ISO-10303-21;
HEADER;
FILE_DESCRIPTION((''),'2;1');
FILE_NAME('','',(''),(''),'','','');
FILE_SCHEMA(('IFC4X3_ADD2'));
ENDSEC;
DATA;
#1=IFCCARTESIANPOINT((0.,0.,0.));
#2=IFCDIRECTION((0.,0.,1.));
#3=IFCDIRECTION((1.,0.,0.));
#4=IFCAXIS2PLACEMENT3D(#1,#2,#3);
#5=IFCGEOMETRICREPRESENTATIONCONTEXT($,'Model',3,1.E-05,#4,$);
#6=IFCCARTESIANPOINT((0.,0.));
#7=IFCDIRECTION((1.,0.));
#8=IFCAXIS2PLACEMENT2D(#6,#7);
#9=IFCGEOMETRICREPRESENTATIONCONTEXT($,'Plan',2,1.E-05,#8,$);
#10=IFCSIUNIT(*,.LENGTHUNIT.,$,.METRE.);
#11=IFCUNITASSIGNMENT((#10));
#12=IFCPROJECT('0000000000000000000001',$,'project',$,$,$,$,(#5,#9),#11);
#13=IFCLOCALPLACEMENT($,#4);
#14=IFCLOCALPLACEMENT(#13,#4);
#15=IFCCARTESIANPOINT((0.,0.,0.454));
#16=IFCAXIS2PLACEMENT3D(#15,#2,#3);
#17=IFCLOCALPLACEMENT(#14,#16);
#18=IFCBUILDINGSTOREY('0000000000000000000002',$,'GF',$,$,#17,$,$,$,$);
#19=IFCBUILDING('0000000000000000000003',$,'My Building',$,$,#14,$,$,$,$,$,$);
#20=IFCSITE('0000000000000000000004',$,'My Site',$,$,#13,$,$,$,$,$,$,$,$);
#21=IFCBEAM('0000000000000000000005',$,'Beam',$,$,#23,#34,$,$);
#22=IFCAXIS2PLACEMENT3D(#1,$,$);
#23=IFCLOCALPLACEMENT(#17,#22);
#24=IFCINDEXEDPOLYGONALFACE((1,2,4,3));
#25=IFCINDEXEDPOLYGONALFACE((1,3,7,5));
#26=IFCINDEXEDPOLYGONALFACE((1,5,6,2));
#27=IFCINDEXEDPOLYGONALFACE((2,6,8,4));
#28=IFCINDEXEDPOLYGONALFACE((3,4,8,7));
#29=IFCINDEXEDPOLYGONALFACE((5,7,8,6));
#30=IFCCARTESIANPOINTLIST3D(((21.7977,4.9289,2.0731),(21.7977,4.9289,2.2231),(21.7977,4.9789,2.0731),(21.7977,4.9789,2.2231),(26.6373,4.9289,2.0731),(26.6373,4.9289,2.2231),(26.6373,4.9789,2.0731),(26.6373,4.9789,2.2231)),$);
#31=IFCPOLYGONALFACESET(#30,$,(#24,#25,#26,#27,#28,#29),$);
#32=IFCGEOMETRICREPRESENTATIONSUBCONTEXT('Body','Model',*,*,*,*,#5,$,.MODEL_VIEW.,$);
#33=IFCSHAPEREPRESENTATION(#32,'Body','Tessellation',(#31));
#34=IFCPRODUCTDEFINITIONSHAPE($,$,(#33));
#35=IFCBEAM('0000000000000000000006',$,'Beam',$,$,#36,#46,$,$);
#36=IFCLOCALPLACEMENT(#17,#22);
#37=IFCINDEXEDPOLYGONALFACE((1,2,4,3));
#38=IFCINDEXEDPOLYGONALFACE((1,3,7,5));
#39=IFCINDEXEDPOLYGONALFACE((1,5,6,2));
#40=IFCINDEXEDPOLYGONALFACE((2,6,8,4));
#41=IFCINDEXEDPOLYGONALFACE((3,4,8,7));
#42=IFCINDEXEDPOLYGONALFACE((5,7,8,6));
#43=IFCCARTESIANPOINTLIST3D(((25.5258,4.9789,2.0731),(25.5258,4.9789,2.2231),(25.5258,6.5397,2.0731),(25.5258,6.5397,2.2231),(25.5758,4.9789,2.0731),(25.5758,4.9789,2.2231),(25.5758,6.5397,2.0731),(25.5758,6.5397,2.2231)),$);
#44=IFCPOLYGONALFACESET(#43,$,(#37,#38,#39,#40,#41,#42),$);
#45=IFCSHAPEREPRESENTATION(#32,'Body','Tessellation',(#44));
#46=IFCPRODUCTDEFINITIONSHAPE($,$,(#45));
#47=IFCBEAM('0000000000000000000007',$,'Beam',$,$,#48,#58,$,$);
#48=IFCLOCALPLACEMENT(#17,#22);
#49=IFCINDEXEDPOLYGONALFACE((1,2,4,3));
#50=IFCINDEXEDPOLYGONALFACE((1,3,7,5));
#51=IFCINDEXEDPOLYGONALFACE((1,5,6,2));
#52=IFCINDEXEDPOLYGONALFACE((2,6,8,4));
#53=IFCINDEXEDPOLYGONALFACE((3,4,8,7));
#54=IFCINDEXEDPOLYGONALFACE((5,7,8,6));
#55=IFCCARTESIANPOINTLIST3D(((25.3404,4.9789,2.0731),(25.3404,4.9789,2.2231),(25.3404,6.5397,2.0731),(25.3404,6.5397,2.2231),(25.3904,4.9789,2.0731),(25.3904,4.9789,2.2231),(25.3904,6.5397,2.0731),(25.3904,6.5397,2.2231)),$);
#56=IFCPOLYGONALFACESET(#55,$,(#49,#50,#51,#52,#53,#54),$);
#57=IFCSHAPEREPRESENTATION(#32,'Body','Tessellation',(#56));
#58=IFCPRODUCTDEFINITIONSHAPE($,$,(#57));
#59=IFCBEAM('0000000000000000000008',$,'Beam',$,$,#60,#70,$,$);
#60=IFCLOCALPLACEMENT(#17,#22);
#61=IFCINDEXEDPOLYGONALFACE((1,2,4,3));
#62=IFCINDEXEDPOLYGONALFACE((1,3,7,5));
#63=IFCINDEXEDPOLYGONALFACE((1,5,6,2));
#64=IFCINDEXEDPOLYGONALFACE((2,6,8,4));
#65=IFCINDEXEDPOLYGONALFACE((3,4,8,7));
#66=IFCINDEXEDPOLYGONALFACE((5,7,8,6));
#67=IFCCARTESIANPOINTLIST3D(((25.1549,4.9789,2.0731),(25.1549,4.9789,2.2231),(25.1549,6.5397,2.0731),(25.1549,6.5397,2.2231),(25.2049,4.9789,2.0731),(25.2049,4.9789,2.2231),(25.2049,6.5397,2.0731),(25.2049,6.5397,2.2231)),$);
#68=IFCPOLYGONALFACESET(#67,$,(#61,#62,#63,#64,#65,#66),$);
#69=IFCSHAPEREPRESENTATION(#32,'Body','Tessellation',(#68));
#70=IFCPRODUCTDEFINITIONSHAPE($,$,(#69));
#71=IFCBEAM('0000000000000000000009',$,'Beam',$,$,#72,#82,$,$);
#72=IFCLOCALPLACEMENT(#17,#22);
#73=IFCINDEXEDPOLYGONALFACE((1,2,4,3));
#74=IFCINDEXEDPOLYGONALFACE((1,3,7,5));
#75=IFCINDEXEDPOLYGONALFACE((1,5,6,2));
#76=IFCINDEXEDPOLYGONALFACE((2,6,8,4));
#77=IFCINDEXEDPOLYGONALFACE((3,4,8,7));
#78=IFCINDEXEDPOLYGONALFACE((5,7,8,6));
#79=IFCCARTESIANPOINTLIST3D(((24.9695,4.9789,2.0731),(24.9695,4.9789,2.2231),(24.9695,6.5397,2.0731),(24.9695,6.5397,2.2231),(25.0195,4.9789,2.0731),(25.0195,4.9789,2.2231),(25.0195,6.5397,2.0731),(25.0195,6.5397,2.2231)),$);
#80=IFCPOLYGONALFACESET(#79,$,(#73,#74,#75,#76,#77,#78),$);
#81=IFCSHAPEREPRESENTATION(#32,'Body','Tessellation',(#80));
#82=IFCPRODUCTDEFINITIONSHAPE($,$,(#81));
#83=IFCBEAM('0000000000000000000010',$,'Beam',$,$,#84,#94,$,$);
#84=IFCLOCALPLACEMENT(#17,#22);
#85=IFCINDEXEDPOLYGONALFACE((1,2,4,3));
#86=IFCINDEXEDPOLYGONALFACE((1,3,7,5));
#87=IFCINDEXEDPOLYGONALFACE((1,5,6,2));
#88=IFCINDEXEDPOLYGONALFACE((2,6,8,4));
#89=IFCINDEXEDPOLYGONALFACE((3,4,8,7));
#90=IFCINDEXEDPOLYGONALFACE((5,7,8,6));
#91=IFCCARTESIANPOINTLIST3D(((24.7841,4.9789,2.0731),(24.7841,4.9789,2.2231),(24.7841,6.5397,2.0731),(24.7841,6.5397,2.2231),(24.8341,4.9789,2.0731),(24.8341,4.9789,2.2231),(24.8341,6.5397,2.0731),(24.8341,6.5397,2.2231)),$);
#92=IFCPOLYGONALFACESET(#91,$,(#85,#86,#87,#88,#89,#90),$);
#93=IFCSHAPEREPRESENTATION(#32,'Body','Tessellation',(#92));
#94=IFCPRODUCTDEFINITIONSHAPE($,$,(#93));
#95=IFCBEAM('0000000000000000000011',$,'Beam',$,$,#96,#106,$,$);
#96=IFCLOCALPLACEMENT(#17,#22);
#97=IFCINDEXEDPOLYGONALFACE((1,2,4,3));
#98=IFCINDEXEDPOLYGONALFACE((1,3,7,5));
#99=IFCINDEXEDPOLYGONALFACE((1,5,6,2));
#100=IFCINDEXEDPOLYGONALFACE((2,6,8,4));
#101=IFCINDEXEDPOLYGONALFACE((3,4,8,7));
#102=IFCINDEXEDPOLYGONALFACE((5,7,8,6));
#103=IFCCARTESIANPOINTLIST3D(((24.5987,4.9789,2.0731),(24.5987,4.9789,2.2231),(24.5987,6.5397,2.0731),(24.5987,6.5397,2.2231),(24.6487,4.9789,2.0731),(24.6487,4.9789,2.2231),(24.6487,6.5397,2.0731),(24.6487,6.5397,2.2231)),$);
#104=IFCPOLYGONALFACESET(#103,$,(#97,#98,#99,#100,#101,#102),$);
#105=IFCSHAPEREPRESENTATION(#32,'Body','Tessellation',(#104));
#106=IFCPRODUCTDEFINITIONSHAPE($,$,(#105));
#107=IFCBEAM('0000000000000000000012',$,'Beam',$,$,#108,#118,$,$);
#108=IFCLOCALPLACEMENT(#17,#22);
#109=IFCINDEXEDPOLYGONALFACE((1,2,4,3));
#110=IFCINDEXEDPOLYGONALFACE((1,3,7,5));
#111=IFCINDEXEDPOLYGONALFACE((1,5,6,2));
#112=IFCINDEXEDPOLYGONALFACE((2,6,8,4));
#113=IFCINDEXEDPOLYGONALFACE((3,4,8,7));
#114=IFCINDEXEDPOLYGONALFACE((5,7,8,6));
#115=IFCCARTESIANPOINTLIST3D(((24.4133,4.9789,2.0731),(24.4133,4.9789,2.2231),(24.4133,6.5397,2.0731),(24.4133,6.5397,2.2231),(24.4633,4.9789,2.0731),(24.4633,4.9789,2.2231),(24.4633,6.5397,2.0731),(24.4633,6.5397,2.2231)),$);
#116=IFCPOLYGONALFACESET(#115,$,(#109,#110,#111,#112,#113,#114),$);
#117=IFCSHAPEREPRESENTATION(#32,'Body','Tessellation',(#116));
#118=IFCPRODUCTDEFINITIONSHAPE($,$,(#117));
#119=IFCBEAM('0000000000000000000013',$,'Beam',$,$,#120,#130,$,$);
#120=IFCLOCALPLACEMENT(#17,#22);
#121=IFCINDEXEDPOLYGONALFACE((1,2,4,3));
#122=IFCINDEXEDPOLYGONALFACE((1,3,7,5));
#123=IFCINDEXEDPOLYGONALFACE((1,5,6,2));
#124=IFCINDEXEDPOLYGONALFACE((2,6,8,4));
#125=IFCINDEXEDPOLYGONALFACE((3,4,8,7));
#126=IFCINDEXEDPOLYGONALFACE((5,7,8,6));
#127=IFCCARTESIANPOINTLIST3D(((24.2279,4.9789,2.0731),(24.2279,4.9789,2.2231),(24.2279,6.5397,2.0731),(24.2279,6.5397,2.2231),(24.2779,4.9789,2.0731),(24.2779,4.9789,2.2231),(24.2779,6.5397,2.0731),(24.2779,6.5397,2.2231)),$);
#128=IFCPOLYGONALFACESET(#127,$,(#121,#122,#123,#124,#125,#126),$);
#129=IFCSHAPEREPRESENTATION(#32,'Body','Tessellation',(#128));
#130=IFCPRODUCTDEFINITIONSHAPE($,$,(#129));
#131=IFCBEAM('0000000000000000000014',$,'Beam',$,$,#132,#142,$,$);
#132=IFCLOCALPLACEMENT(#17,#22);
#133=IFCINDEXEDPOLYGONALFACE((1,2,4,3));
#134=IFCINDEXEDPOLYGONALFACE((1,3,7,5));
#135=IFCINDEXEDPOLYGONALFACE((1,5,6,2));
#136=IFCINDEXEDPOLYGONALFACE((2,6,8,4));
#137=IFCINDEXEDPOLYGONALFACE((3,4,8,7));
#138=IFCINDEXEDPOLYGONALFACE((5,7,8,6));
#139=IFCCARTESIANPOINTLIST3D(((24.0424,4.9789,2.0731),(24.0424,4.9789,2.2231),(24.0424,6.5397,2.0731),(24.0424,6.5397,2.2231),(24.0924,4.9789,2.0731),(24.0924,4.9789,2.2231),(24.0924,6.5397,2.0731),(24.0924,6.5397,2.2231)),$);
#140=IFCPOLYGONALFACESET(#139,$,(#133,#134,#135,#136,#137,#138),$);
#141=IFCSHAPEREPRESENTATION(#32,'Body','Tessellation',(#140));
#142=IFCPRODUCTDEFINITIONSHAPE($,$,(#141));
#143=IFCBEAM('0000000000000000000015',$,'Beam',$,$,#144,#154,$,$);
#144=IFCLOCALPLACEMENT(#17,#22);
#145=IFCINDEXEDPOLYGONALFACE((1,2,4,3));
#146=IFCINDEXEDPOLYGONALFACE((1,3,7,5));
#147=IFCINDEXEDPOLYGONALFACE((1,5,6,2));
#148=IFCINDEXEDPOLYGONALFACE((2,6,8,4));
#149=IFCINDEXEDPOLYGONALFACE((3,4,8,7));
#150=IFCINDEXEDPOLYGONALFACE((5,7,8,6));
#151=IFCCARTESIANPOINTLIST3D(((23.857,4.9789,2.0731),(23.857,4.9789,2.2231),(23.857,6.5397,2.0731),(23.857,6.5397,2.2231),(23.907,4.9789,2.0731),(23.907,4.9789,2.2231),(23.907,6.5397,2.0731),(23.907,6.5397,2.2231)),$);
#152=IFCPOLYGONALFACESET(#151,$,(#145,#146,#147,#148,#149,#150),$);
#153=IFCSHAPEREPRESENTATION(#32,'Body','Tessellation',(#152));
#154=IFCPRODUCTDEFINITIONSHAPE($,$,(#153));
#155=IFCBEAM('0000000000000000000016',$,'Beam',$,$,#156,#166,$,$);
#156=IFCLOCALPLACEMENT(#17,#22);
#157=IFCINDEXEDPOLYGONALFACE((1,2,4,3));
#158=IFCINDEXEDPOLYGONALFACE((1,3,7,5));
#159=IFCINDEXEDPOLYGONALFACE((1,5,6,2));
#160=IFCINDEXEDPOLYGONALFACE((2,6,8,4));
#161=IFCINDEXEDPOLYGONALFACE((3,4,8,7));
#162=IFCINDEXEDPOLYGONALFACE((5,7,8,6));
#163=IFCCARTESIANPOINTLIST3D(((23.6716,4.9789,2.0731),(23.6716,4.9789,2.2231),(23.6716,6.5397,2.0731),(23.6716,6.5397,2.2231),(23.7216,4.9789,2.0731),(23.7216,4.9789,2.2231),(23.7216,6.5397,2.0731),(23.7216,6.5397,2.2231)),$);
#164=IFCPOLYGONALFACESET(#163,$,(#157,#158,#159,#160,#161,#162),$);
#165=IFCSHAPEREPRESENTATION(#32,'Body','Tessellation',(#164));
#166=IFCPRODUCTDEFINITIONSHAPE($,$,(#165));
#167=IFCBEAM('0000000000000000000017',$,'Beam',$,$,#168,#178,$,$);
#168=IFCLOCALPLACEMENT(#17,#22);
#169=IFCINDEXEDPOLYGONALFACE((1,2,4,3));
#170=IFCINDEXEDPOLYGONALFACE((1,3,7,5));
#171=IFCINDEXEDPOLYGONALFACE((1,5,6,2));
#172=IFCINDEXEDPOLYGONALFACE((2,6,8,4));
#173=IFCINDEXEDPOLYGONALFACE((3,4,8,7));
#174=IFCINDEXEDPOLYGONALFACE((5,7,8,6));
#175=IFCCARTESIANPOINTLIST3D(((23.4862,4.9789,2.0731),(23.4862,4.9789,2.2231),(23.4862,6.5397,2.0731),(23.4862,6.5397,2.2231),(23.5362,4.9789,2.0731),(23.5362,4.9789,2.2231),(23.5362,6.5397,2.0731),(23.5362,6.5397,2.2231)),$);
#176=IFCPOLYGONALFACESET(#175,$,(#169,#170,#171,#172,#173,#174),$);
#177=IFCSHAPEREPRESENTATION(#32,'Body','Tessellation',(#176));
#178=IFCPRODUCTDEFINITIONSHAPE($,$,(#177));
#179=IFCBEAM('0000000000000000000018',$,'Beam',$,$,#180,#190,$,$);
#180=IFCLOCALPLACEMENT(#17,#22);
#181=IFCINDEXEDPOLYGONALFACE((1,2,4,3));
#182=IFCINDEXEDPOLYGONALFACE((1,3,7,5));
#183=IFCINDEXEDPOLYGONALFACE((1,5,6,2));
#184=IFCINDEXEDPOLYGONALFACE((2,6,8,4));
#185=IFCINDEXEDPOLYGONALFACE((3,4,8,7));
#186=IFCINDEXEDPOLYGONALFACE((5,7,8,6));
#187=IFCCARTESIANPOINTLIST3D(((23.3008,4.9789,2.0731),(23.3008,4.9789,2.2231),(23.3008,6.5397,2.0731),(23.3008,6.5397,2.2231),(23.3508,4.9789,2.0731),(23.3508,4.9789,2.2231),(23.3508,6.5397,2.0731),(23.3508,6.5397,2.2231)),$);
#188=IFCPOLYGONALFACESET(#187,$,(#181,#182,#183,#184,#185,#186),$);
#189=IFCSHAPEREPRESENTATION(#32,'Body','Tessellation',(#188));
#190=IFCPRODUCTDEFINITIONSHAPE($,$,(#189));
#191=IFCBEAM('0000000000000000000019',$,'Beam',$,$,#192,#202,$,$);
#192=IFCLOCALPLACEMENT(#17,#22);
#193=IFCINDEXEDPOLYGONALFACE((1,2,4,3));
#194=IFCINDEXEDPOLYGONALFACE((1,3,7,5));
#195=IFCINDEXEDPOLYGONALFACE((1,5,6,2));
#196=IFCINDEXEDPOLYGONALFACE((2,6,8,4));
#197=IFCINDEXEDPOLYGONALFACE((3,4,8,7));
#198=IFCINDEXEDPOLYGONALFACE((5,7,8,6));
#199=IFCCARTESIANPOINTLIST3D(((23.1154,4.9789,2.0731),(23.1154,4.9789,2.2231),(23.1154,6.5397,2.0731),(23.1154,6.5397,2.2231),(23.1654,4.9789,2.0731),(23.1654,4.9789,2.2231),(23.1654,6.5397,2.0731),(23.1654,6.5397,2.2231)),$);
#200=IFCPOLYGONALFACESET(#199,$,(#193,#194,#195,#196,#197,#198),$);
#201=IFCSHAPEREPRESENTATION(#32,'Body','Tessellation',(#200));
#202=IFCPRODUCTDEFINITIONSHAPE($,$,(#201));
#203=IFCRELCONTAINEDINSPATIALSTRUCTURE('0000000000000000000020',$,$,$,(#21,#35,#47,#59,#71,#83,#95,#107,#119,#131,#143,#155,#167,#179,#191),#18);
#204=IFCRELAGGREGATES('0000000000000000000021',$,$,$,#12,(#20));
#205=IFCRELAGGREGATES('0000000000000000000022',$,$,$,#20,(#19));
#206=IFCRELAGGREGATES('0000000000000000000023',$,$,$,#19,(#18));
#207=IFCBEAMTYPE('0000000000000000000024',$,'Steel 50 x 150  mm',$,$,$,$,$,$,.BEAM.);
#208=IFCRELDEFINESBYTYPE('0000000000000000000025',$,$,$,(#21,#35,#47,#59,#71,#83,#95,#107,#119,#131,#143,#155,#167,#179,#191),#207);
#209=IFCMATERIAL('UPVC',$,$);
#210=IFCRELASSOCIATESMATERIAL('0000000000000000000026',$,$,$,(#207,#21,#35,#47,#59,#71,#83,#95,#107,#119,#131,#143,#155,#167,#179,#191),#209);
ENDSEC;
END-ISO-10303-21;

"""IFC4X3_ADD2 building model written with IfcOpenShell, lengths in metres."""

from ifc_helpers import new_model, si_unit, frame, origin_with_axes, origin_2d_with_axis, place, context, subcontext, project, spatial, rectangle, extrude, material, material_profile, profile_set, profile_usage, type_object, element, save


model = new_model("IFC4X3_ADD2")

# Units and contexts
model_context = context("Model", 3, precision=1e-05, world=origin_with_axes())
plan_context = context("Plan", 2, precision=1e-05, world=origin_2d_with_axis())
body_context_1 = subcontext(model_context, "Body", "Model", "MODEL_VIEW")
ifc_project = project(units=[si_unit("LENGTHUNIT", "METRE")], contexts=[model_context, plan_context])

# Site, building, storey
site_placement = place(None, origin_with_axes())
site = spatial("IfcSite", under=ifc_project, at=site_placement, Name="My Site")
building_placement = place(site_placement, origin_with_axes())
building = spatial("IfcBuilding", under=site, at=building_placement, Name="My Building")
storey_placement = place(building_placement, frame((0.0, 0.0, 0.454), z_axis=(0.0, 0.0, 1.0), x_axis=(1.0, 0.0, 0.0)))
storey = spatial("IfcBuildingStorey", under=building, at=storey_placement, Name="GF")

# Beams
ifc_material_1 = material(Name="UPVC")
ifc_material_profile_1 = material_profile(ifc_material_1, rectangle(XDim=0.05, YDim=0.15))
ifc_profile_set_1 = profile_set([ifc_material_profile_1])
ifc_profile_usage_1 = profile_usage(ifc_profile_set_1)
beam_type_1 = type_object("IfcBeamType", Name="Steel 50 x 150  mm", PredefinedType="BEAM", material=ifc_profile_set_1)
beam_1_placement = place(storey_placement, frame((21.7977, 4.9539, 2.1481), z_axis=(1.0, 0.0, 0.0), x_axis=(0.0, 1.0, 0.0)))
element("IfcBeam", 1, at=beam_1_placement, inside=storey, type_object=beam_type_1, material=ifc_profile_usage_1, Name="Beam", context=body_context_1, shape_type="SweptSolid", body=[
    extrude(rectangle(XDim=0.05, YDim=0.15), origin_with_axes(), (0.0, 0.0, 1.0), 4.8396),
])
ifc_profile_usage_2 = profile_usage(ifc_profile_set_1)
beam_2_placement = place(storey_placement, frame((25.5508, 6.5397, 2.1481), z_axis=(0.0, -1.0, 0.0), x_axis=(1.0, 0.0, 0.0)))
element("IfcBeam", 2, at=beam_2_placement, inside=storey, type_object=beam_type_1, material=ifc_profile_usage_2, Name="Beam", context=body_context_1, shape_type="SweptSolid", body=[
    extrude(rectangle(XDim=0.05, YDim=0.15), origin_with_axes(), (0.0, 0.0, 1.0), 1.5608),
])
ifc_profile_usage_3 = profile_usage(ifc_profile_set_1)
beam_3_placement = place(storey_placement, frame((25.3654, 6.5397, 2.1481), z_axis=(0.0, -1.0, 0.0), x_axis=(1.0, 0.0, 0.0)))
element("IfcBeam", 3, at=beam_3_placement, inside=storey, type_object=beam_type_1, material=ifc_profile_usage_3, Name="Beam", context=body_context_1, shape_type="SweptSolid", body=[
    extrude(rectangle(XDim=0.05, YDim=0.15), origin_with_axes(), (0.0, 0.0, 1.0), 1.5608),
])
ifc_profile_usage_4 = profile_usage(ifc_profile_set_1)
beam_4_placement = place(storey_placement, frame((25.1799, 6.5397, 2.1481), z_axis=(0.0, -1.0, 0.0), x_axis=(1.0, 0.0, 0.0)))
element("IfcBeam", 4, at=beam_4_placement, inside=storey, type_object=beam_type_1, material=ifc_profile_usage_4, Name="Beam", context=body_context_1, shape_type="SweptSolid", body=[
    extrude(rectangle(XDim=0.05, YDim=0.15), origin_with_axes(), (0.0, 0.0, 1.0), 1.5608),
])
ifc_profile_usage_5 = profile_usage(ifc_profile_set_1)
beam_5_placement = place(storey_placement, frame((24.9945, 6.5397, 2.1481), z_axis=(0.0, -1.0, 0.0), x_axis=(1.0, 0.0, 0.0)))
element("IfcBeam", 5, at=beam_5_placement, inside=storey, type_object=beam_type_1, material=ifc_profile_usage_5, Name="Beam", context=body_context_1, shape_type="SweptSolid", body=[
    extrude(rectangle(XDim=0.05, YDim=0.15), origin_with_axes(), (0.0, 0.0, 1.0), 1.5608),
])
ifc_profile_usage_6 = profile_usage(ifc_profile_set_1)
beam_6_placement = place(storey_placement, frame((24.8091, 6.5397, 2.1481), z_axis=(0.0, -1.0, 0.0), x_axis=(1.0, 0.0, 0.0)))
element("IfcBeam", 6, at=beam_6_placement, inside=storey, type_object=beam_type_1, material=ifc_profile_usage_6, Name="Beam", context=body_context_1, shape_type="SweptSolid", body=[
    extrude(rectangle(XDim=0.05, YDim=0.15), origin_with_axes(), (0.0, 0.0, 1.0), 1.5608),
])
ifc_profile_usage_7 = profile_usage(ifc_profile_set_1)
beam_7_placement = place(storey_placement, frame((24.6237, 6.5397, 2.1481), z_axis=(0.0, -1.0, 0.0), x_axis=(1.0, 0.0, 0.0)))
element("IfcBeam", 7, at=beam_7_placement, inside=storey, type_object=beam_type_1, material=ifc_profile_usage_7, Name="Beam", context=body_context_1, shape_type="SweptSolid", body=[
    extrude(rectangle(XDim=0.05, YDim=0.15), origin_with_axes(), (0.0, 0.0, 1.0), 1.5608),
])
ifc_profile_usage_8 = profile_usage(ifc_profile_set_1)
beam_8_placement = place(storey_placement, frame((24.4383, 6.5397, 2.1481), z_axis=(0.0, -1.0, 0.0), x_axis=(1.0, 0.0, 0.0)))
element("IfcBeam", 8, at=beam_8_placement, inside=storey, type_object=beam_type_1, material=ifc_profile_usage_8, Name="Beam", context=body_context_1, shape_type="SweptSolid", body=[
    extrude(rectangle(XDim=0.05, YDim=0.15), origin_with_axes(), (0.0, 0.0, 1.0), 1.5608),
])
ifc_profile_usage_9 = profile_usage(ifc_profile_set_1)
beam_9_placement = place(storey_placement, frame((24.2529, 6.5397, 2.1481), z_axis=(0.0, -1.0, 0.0), x_axis=(1.0, 0.0, 0.0)))
element("IfcBeam", 9, at=beam_9_placement, inside=storey, type_object=beam_type_1, material=ifc_profile_usage_9, Name="Beam", context=body_context_1, shape_type="SweptSolid", body=[
    extrude(rectangle(XDim=0.05, YDim=0.15), origin_with_axes(), (0.0, 0.0, 1.0), 1.5608),
])
ifc_profile_usage_10 = profile_usage(ifc_profile_set_1)
beam_10_placement = place(storey_placement, frame((24.0674, 6.5397, 2.1481), z_axis=(0.0, -1.0, 0.0), x_axis=(1.0, 0.0, 0.0)))
element("IfcBeam", 10, at=beam_10_placement, inside=storey, type_object=beam_type_1, material=ifc_profile_usage_10, Name="Beam", context=body_context_1, shape_type="SweptSolid", body=[
    extrude(rectangle(XDim=0.05, YDim=0.15), origin_with_axes(), (0.0, 0.0, 1.0), 1.5608),
])
ifc_profile_usage_11 = profile_usage(ifc_profile_set_1)
beam_11_placement = place(storey_placement, frame((23.882, 6.5397, 2.1481), z_axis=(0.0, -1.0, 0.0), x_axis=(1.0, 0.0, 0.0)))
element("IfcBeam", 11, at=beam_11_placement, inside=storey, type_object=beam_type_1, material=ifc_profile_usage_11, Name="Beam", context=body_context_1, shape_type="SweptSolid", body=[
    extrude(rectangle(XDim=0.05, YDim=0.15), origin_with_axes(), (0.0, 0.0, 1.0), 1.5608),
])
ifc_profile_usage_12 = profile_usage(ifc_profile_set_1)
beam_12_placement = place(storey_placement, frame((23.6966, 6.5397, 2.1481), z_axis=(0.0, -1.0, 0.0), x_axis=(1.0, 0.0, 0.0)))
element("IfcBeam", 12, at=beam_12_placement, inside=storey, type_object=beam_type_1, material=ifc_profile_usage_12, Name="Beam", context=body_context_1, shape_type="SweptSolid", body=[
    extrude(rectangle(XDim=0.05, YDim=0.15), origin_with_axes(), (0.0, 0.0, 1.0), 1.5608),
])
ifc_profile_usage_13 = profile_usage(ifc_profile_set_1)
beam_13_placement = place(storey_placement, frame((23.5112, 6.5397, 2.1481), z_axis=(0.0, -1.0, 0.0), x_axis=(1.0, 0.0, 0.0)))
element("IfcBeam", 13, at=beam_13_placement, inside=storey, type_object=beam_type_1, material=ifc_profile_usage_13, Name="Beam", context=body_context_1, shape_type="SweptSolid", body=[
    extrude(rectangle(XDim=0.05, YDim=0.15), origin_with_axes(), (0.0, 0.0, 1.0), 1.5608),
])
ifc_profile_usage_14 = profile_usage(ifc_profile_set_1)
beam_14_placement = place(storey_placement, frame((23.3258, 6.5397, 2.1481), z_axis=(0.0, -1.0, 0.0), x_axis=(1.0, 0.0, 0.0)))
element("IfcBeam", 14, at=beam_14_placement, inside=storey, type_object=beam_type_1, material=ifc_profile_usage_14, Name="Beam", context=body_context_1, shape_type="SweptSolid", body=[
    extrude(rectangle(XDim=0.05, YDim=0.15), origin_with_axes(), (0.0, 0.0, 1.0), 1.5608),
])
ifc_profile_usage_15 = profile_usage(ifc_profile_set_1)
beam_15_placement = place(storey_placement, frame((23.1404, 6.5397, 2.1481), z_axis=(0.0, -1.0, 0.0), x_axis=(1.0, 0.0, 0.0)))
element("IfcBeam", 15, at=beam_15_placement, inside=storey, type_object=beam_type_1, material=ifc_profile_usage_15, Name="Beam", context=body_context_1, shape_type="SweptSolid", body=[
    extrude(rectangle(XDim=0.05, YDim=0.15), origin_with_axes(), (0.0, 0.0, 1.0), 1.5608),
])

save(model, "model.ifc")
